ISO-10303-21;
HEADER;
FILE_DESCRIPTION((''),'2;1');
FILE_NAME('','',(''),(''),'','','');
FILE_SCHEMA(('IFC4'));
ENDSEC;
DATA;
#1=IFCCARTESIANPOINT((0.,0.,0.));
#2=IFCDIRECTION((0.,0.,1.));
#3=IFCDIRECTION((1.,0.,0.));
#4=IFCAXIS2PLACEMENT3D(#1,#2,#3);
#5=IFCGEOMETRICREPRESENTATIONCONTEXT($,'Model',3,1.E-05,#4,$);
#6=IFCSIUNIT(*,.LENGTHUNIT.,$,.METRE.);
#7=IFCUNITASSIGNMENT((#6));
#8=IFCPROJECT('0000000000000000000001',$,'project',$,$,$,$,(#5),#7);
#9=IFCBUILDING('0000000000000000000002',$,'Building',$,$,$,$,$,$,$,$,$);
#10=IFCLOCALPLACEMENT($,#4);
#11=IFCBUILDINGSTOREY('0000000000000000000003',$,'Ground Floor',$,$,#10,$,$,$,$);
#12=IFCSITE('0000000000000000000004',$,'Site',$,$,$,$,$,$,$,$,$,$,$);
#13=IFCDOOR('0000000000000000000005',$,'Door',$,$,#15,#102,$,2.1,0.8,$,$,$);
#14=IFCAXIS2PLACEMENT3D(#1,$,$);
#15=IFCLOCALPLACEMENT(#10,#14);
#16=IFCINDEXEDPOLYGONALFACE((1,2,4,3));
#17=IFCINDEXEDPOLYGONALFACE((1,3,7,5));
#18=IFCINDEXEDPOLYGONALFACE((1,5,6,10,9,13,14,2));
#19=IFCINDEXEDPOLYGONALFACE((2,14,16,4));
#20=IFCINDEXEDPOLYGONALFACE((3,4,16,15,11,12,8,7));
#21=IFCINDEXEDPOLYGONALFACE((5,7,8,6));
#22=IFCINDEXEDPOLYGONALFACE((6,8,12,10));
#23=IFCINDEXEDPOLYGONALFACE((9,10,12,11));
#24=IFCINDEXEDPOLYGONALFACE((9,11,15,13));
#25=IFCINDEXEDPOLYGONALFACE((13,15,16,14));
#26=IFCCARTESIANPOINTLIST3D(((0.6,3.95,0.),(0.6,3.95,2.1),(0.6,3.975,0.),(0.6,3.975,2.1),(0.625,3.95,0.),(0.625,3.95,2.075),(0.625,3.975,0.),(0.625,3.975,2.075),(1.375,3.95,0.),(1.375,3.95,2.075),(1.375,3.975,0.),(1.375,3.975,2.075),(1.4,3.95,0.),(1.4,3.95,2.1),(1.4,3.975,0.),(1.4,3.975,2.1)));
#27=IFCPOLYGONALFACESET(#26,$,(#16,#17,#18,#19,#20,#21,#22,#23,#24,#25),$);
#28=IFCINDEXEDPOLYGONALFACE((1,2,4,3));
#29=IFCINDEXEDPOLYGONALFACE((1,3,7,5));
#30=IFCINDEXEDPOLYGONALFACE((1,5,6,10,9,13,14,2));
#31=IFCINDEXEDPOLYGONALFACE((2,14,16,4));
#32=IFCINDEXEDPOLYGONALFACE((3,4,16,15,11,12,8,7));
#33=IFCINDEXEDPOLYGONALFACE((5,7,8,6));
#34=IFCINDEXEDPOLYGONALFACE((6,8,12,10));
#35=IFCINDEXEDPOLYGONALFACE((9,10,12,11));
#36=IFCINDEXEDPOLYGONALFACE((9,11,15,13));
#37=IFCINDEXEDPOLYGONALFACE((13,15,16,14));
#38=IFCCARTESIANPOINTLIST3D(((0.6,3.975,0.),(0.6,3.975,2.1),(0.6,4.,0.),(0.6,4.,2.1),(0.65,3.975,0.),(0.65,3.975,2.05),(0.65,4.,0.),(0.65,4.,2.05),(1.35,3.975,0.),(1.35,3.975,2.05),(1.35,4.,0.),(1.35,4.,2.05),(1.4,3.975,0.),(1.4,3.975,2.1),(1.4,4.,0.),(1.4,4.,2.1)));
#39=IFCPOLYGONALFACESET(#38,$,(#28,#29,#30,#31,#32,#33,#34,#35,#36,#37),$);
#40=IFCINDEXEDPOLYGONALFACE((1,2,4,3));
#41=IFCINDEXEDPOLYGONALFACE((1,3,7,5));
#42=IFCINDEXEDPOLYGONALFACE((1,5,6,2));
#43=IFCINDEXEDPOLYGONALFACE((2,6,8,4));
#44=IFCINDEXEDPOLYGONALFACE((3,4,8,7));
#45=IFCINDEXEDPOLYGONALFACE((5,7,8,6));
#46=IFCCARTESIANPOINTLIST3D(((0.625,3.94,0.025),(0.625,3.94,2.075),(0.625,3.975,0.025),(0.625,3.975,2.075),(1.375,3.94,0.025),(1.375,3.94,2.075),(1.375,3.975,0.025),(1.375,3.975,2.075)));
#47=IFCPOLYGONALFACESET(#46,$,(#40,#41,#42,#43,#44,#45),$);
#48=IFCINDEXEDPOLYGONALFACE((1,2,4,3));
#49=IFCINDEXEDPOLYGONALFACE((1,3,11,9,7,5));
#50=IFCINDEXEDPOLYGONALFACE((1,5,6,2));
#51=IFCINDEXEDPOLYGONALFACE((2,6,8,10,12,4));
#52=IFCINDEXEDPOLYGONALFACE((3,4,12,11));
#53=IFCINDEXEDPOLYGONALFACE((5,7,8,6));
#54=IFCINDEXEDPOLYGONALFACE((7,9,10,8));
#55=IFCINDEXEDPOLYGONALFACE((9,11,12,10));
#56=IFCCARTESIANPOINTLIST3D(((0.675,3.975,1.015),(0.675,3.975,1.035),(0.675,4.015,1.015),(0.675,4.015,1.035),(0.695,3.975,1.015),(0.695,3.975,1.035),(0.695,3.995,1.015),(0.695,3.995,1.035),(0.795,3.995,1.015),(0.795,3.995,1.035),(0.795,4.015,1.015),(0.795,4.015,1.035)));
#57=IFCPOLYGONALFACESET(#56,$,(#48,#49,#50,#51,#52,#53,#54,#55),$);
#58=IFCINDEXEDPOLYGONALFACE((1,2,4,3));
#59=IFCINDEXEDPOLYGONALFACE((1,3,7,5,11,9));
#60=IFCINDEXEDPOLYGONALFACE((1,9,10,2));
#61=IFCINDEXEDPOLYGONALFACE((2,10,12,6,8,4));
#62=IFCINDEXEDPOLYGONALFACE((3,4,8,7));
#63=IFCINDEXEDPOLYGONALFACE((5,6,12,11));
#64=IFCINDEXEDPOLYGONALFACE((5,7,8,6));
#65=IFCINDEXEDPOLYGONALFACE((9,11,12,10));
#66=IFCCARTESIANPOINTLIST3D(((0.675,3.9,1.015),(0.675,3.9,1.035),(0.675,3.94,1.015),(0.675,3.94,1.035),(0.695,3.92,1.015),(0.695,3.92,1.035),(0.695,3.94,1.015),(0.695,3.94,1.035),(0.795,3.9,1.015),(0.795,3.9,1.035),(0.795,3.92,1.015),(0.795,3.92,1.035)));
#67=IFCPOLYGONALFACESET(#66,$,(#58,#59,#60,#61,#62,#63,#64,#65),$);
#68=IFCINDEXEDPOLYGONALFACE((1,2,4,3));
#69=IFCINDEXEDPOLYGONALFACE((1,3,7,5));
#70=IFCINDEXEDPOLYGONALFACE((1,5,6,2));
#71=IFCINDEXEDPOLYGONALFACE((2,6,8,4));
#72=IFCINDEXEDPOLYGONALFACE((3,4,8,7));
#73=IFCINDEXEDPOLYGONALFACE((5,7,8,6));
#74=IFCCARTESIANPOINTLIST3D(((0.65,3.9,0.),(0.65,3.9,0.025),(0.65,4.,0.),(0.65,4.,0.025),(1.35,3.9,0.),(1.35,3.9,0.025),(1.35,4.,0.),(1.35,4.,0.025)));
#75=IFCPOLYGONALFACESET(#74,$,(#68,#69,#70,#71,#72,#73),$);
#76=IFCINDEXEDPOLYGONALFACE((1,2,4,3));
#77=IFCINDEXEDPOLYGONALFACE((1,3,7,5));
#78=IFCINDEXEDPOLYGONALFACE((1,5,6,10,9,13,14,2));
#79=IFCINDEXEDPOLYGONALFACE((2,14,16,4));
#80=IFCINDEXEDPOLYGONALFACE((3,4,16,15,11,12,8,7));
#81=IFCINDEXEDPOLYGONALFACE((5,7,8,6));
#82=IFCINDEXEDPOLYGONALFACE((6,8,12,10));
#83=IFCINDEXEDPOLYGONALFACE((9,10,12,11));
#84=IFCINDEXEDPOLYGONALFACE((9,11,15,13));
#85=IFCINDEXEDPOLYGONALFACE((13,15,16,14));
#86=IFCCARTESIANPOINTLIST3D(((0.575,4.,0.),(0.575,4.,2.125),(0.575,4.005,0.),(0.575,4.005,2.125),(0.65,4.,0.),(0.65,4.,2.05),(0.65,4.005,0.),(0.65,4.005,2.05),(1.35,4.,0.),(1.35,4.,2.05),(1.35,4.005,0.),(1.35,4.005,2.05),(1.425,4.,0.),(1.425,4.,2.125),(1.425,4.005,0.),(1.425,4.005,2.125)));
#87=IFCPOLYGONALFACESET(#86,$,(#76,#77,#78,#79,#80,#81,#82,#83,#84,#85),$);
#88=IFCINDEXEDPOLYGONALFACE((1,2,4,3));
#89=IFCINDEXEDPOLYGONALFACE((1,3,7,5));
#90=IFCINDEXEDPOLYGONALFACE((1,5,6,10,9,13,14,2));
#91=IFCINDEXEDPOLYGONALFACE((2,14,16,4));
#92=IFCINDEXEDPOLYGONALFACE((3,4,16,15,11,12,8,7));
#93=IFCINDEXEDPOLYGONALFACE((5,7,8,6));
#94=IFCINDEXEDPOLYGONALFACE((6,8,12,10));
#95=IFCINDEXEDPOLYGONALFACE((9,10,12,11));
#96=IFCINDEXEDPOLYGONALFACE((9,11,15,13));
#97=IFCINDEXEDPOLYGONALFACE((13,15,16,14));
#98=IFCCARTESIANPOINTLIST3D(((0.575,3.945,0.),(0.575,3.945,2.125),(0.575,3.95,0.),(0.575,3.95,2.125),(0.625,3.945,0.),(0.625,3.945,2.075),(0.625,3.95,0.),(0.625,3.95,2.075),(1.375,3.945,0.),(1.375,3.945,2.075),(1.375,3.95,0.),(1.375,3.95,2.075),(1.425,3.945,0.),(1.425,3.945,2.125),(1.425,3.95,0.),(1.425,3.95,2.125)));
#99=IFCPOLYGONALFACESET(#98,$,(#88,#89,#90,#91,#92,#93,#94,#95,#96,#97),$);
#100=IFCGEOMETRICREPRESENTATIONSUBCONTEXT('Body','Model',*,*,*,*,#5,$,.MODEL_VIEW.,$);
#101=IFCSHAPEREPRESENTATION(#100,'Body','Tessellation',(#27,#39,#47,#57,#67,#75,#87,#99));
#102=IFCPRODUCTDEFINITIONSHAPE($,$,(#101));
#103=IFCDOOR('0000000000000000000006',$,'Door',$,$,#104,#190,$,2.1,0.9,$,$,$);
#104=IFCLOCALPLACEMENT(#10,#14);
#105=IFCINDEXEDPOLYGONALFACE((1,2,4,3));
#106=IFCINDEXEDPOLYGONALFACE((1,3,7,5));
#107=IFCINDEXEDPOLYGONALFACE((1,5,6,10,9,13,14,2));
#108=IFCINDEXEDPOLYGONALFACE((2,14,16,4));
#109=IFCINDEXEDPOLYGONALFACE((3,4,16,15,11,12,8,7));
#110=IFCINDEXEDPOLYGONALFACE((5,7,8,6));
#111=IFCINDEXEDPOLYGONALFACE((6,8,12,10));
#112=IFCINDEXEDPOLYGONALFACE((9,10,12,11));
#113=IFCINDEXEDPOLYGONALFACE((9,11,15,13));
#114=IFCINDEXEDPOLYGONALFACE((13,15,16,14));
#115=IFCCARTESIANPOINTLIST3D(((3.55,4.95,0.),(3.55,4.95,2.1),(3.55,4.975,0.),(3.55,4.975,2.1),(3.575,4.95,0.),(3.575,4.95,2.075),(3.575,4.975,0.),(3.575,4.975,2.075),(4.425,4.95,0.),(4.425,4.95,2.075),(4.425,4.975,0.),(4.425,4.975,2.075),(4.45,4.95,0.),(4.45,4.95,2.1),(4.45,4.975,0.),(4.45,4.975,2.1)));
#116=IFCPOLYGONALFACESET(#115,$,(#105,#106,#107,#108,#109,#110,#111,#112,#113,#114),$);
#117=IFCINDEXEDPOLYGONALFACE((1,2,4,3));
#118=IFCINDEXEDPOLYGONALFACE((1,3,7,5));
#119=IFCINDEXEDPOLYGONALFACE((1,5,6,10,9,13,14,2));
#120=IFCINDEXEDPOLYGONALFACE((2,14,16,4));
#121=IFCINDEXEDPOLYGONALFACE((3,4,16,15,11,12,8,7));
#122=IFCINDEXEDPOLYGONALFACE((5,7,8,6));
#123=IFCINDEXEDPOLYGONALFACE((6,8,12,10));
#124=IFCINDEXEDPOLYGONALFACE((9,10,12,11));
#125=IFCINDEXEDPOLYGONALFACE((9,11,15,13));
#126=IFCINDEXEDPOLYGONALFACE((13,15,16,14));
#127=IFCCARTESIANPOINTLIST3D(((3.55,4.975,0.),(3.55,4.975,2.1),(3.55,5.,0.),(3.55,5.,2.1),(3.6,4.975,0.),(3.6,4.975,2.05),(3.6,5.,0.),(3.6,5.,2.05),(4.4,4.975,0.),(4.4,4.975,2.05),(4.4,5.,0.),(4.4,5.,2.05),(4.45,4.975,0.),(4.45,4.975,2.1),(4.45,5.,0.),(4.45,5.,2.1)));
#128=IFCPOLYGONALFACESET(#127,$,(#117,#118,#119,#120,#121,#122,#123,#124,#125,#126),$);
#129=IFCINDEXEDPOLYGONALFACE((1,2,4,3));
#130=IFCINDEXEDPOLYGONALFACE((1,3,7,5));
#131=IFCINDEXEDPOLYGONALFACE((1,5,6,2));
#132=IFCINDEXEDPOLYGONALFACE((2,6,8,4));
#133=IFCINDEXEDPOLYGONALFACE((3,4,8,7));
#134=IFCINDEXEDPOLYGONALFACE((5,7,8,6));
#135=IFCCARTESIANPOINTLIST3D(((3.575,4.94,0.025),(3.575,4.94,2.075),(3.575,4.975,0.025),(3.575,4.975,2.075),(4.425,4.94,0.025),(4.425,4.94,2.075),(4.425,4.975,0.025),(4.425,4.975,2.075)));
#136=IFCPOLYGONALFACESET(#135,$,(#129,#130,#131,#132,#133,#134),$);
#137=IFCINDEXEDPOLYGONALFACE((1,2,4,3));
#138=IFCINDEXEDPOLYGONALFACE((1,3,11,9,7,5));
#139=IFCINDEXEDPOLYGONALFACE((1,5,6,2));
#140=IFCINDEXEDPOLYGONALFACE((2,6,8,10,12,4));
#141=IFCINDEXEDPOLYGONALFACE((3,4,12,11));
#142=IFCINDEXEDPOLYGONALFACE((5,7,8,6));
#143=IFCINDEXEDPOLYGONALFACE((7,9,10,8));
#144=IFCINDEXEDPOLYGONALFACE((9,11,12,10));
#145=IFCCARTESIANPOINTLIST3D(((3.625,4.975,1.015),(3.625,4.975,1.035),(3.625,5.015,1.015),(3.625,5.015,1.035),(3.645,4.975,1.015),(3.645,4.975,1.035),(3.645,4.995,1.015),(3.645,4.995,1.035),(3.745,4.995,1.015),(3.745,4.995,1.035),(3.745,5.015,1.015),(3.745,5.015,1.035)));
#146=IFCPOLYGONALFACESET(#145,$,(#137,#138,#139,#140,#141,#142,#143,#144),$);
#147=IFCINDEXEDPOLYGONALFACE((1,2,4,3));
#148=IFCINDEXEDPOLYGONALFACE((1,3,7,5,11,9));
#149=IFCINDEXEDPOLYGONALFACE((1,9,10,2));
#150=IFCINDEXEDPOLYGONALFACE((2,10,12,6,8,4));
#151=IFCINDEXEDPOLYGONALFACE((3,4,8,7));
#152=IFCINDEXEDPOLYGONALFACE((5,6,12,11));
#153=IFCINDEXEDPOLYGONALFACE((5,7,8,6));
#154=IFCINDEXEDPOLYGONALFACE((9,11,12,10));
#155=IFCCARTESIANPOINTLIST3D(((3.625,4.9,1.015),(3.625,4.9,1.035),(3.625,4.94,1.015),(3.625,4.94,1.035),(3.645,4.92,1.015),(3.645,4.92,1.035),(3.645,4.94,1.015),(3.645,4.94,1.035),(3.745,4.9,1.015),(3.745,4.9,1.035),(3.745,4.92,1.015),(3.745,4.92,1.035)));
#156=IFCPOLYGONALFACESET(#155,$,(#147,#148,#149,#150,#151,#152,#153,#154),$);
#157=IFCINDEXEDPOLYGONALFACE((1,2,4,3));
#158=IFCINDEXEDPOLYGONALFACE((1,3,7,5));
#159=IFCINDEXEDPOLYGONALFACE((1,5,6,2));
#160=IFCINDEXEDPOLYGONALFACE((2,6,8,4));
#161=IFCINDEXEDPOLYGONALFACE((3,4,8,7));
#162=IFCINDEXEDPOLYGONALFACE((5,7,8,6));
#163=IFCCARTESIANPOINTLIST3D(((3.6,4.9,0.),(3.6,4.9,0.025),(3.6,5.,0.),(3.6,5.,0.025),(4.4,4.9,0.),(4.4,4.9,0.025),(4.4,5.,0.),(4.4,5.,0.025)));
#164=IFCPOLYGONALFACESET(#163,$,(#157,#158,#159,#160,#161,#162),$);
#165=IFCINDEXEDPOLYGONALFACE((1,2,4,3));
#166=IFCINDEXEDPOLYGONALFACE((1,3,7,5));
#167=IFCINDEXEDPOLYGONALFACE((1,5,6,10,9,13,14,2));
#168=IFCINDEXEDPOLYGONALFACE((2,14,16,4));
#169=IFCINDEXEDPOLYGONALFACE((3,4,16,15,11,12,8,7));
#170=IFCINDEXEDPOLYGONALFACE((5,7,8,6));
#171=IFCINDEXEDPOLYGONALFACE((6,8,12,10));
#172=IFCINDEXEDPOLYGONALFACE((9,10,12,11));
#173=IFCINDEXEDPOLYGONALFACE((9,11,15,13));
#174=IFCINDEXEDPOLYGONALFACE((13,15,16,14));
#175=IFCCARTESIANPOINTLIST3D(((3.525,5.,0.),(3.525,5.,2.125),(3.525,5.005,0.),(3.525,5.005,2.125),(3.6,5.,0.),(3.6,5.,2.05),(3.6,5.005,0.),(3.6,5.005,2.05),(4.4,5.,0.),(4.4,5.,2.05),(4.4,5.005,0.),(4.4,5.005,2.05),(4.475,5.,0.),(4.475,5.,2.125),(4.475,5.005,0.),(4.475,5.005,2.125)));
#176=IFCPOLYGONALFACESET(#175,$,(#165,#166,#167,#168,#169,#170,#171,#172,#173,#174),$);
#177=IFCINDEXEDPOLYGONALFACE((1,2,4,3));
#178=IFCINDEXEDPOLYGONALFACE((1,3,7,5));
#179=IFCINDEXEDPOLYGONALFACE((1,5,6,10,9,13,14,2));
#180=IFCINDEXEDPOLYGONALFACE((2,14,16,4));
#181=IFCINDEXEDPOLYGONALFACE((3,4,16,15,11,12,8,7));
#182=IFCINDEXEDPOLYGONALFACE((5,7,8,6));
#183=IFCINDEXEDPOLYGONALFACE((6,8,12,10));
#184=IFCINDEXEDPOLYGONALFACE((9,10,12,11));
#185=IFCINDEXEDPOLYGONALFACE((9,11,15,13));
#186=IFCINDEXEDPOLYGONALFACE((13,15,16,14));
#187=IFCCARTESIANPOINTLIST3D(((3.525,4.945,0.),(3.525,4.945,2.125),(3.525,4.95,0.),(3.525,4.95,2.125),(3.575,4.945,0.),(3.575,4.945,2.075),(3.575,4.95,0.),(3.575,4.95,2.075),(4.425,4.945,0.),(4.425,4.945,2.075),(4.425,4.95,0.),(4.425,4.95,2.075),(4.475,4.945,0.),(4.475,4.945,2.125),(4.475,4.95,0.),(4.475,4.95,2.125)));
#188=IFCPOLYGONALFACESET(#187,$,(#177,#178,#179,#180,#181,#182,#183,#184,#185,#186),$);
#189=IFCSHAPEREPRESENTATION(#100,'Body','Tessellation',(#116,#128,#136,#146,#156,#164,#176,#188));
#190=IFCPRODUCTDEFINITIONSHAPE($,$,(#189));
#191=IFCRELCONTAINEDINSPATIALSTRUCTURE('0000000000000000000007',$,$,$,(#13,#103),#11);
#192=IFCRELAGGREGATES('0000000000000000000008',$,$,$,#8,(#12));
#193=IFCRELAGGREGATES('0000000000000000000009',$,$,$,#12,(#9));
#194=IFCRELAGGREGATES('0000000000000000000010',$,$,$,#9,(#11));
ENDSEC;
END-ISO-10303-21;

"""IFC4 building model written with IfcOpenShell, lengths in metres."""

from ifc_helpers import new_model, si_unit, frame, origin_with_axes, place, context, subcontext, project, spatial, line, indexed_curve, outline, extrude, element, save


model = new_model("IFC4")

# Units and contexts
model_context = context("Model", 3, precision=1e-05, world=origin_with_axes())
body_context = subcontext(model_context, "Body", "Model", "MODEL_VIEW")
ifc_project = project(units=[si_unit("LENGTHUNIT", "METRE")], contexts=[model_context])

# Site, building, storey
site = spatial("IfcSite", under=ifc_project, Name="Site")
building = spatial("IfcBuilding", under=site, Name="Building")
storey_placement = place(None, origin_with_axes())
storey = spatial("IfcBuildingStorey", under=building, at=storey_placement, Name="Ground Floor")

# Doors
door_1_placement = place(storey_placement, frame((1.4, 4.0, 0.0), z_axis=(0.0, 0.0, 1.0), x_axis=(-1.0, 0.0, 0.0)))
element("IfcDoor", 1, at=door_1_placement, inside=storey, Name="Door", OverallHeight=2.1, OverallWidth=0.8, context=body_context, shape_type="SweptSolid", body=[
    extrude(outline(indexed_curve([(0.0, 0.0), (0.0, 2.1), (0.8, 2.1), (0.8, 0.0), (0.775, 0.0), (0.775, 2.075), (0.025, 2.075), (0.025, 0.0)], segments=[line(1, 2, 3, 4, 5, 6, 7, 8, 1)])), frame((0.0, 0.025, 0.0), z_axis=(0.0, -1.0, 0.0), x_axis=(1.0, 0.0, 0.0)), (0.0, 0.0, -1.0), 0.025),
    extrude(outline(indexed_curve([(0.0, 0.0), (0.0, 2.1), (0.8, 2.1), (0.8, 0.0), (0.75, 0.0), (0.75, 2.05), (0.05, 2.05), (0.05, 0.0)], segments=[line(1, 2, 3, 4, 5, 6, 7, 8, 1)])), frame((0.0, 0.0, 0.0), z_axis=(0.0, -1.0, 0.0), x_axis=(1.0, 0.0, 0.0)), (0.0, 0.0, -1.0), 0.025),
    extrude(outline(indexed_curve([(0.0, 0.0), (0.75, 0.0), (0.75, 0.035), (0.0, 0.035)], segments=[line(1, 2, 3, 4, 1)])), frame((0.025, 0.025, 0.025), z_axis=(0.0, 0.0, 1.0), x_axis=(1.0, 0.0, 0.0)), (0.0, 0.0, 1.0), 2.05),
    extrude(outline(indexed_curve([(0.0, 0.0), (0.0, -0.04), (-0.12, -0.04), (-0.12, -0.02), (-0.02, -0.02), (-0.02, 0.0)], segments=[line(1, 2, 3, 4, 5, 6, 1)])), frame((0.725, 0.025, 1.015), z_axis=(0.0, 0.0, 1.0), x_axis=(1.0, 0.0, 0.0)), (0.0, 0.0, 1.0), 0.02),
    extrude(outline(indexed_curve([(0.0, 0.0), (0.0, 0.04), (-0.12, 0.04), (-0.12, 0.02), (-0.02, 0.02), (-0.02, 0.0)], segments=[line(1, 2, 3, 4, 5, 6, 1)])), frame((0.725, 0.06, 1.015), z_axis=(0.0, 0.0, 1.0), x_axis=(1.0, 0.0, 0.0)), (0.0, 0.0, 1.0), 0.02),
    extrude(outline(indexed_curve([(0.0, 0.0), (0.7, 0.0), (0.7, 0.1), (0.0, 0.1)], segments=[line(1, 2, 3, 4, 1)])), frame((0.05, 0.0, 0.0), z_axis=(0.0, 0.0, 1.0), x_axis=(1.0, 0.0, 0.0)), (0.0, 0.0, 1.0), 0.025),
    extrude(outline(indexed_curve([(0.0, 0.0), (0.0, 2.125), (0.85, 2.125), (0.85, 0.0), (0.775, 0.0), (0.775, 2.05), (0.075, 2.05), (0.075, 0.0)], segments=[line(1, 2, 3, 4, 5, 6, 7, 8, 1)])), frame((-0.025, -0.005, 0.0), z_axis=(0.0, -1.0, 0.0), x_axis=(1.0, 0.0, 0.0)), (0.0, 0.0, -1.0), 0.005),
    extrude(outline(indexed_curve([(0.0, 0.0), (0.0, 2.125), (0.85, 2.125), (0.85, 0.0), (0.8, 0.0), (0.8, 2.075), (0.05, 2.075), (0.05, 0.0)], segments=[line(1, 2, 3, 4, 5, 6, 7, 8, 1)])), frame((-0.025, 0.05, 0.0), z_axis=(0.0, -1.0, 0.0), x_axis=(1.0, 0.0, 0.0)), (0.0, 0.0, -1.0), 0.005),
])
door_2_placement = place(storey_placement, frame((4.45, 5.0, 0.0), z_axis=(0.0, 0.0, 1.0), x_axis=(-1.0, 0.0, 0.0)))
element("IfcDoor", 2, at=door_2_placement, inside=storey, Name="Door", OverallHeight=2.1, OverallWidth=0.9, context=body_context, shape_type="SweptSolid", body=[
    extrude(outline(indexed_curve([(0.0, 0.0), (0.0, 2.1), (0.9, 2.1), (0.9, 0.0), (0.875, 0.0), (0.875, 2.075), (0.025, 2.075), (0.025, 0.0)], segments=[line(1, 2, 3, 4, 5, 6, 7, 8, 1)])), frame((0.0, 0.025, 0.0), z_axis=(0.0, -1.0, 0.0), x_axis=(1.0, 0.0, 0.0)), (0.0, 0.0, -1.0), 0.025),
    extrude(outline(indexed_curve([(0.0, 0.0), (0.0, 2.1), (0.9, 2.1), (0.9, 0.0), (0.85, 0.0), (0.85, 2.05), (0.05, 2.05), (0.05, 0.0)], segments=[line(1, 2, 3, 4, 5, 6, 7, 8, 1)])), frame((0.0, 0.0, 0.0), z_axis=(0.0, -1.0, 0.0), x_axis=(1.0, 0.0, 0.0)), (0.0, 0.0, -1.0), 0.025),
    extrude(outline(indexed_curve([(0.0, 0.0), (0.85, 0.0), (0.85, 0.035), (0.0, 0.035)], segments=[line(1, 2, 3, 4, 1)])), frame((0.025, 0.025, 0.025), z_axis=(0.0, 0.0, 1.0), x_axis=(1.0, 0.0, 0.0)), (0.0, 0.0, 1.0), 2.05),
    extrude(outline(indexed_curve([(0.0, 0.0), (0.0, -0.04), (-0.12, -0.04), (-0.12, -0.02), (-0.02, -0.02), (-0.02, 0.0)], segments=[line(1, 2, 3, 4, 5, 6, 1)])), frame((0.825, 0.025, 1.015), z_axis=(0.0, 0.0, 1.0), x_axis=(1.0, 0.0, 0.0)), (0.0, 0.0, 1.0), 0.02),
    extrude(outline(indexed_curve([(0.0, 0.0), (0.0, 0.04), (-0.12, 0.04), (-0.12, 0.02), (-0.02, 0.02), (-0.02, 0.0)], segments=[line(1, 2, 3, 4, 5, 6, 1)])), frame((0.825, 0.06, 1.015), z_axis=(0.0, 0.0, 1.0), x_axis=(1.0, 0.0, 0.0)), (0.0, 0.0, 1.0), 0.02),
    extrude(outline(indexed_curve([(0.0, 0.0), (0.8, 0.0), (0.8, 0.1), (0.0, 0.1)], segments=[line(1, 2, 3, 4, 1)])), frame((0.05, 0.0, 0.0), z_axis=(0.0, 0.0, 1.0), x_axis=(1.0, 0.0, 0.0)), (0.0, 0.0, 1.0), 0.025),
    extrude(outline(indexed_curve([(0.0, 0.0), (0.0, 2.125), (0.95, 2.125), (0.95, 0.0), (0.875, 0.0), (0.875, 2.05), (0.075, 2.05), (0.075, 0.0)], segments=[line(1, 2, 3, 4, 5, 6, 7, 8, 1)])), frame((-0.025, -0.005, 0.0), z_axis=(0.0, -1.0, 0.0), x_axis=(1.0, 0.0, 0.0)), (0.0, 0.0, -1.0), 0.005),
    extrude(outline(indexed_curve([(0.0, 0.0), (0.0, 2.125), (0.95, 2.125), (0.95, 0.0), (0.9, 0.0), (0.9, 2.075), (0.05, 2.075), (0.05, 0.0)], segments=[line(1, 2, 3, 4, 5, 6, 7, 8, 1)])), frame((-0.025, 0.05, 0.0), z_axis=(0.0, -1.0, 0.0), x_axis=(1.0, 0.0, 0.0)), (0.0, 0.0, -1.0), 0.005),
])

save(model, "model.ifc")
